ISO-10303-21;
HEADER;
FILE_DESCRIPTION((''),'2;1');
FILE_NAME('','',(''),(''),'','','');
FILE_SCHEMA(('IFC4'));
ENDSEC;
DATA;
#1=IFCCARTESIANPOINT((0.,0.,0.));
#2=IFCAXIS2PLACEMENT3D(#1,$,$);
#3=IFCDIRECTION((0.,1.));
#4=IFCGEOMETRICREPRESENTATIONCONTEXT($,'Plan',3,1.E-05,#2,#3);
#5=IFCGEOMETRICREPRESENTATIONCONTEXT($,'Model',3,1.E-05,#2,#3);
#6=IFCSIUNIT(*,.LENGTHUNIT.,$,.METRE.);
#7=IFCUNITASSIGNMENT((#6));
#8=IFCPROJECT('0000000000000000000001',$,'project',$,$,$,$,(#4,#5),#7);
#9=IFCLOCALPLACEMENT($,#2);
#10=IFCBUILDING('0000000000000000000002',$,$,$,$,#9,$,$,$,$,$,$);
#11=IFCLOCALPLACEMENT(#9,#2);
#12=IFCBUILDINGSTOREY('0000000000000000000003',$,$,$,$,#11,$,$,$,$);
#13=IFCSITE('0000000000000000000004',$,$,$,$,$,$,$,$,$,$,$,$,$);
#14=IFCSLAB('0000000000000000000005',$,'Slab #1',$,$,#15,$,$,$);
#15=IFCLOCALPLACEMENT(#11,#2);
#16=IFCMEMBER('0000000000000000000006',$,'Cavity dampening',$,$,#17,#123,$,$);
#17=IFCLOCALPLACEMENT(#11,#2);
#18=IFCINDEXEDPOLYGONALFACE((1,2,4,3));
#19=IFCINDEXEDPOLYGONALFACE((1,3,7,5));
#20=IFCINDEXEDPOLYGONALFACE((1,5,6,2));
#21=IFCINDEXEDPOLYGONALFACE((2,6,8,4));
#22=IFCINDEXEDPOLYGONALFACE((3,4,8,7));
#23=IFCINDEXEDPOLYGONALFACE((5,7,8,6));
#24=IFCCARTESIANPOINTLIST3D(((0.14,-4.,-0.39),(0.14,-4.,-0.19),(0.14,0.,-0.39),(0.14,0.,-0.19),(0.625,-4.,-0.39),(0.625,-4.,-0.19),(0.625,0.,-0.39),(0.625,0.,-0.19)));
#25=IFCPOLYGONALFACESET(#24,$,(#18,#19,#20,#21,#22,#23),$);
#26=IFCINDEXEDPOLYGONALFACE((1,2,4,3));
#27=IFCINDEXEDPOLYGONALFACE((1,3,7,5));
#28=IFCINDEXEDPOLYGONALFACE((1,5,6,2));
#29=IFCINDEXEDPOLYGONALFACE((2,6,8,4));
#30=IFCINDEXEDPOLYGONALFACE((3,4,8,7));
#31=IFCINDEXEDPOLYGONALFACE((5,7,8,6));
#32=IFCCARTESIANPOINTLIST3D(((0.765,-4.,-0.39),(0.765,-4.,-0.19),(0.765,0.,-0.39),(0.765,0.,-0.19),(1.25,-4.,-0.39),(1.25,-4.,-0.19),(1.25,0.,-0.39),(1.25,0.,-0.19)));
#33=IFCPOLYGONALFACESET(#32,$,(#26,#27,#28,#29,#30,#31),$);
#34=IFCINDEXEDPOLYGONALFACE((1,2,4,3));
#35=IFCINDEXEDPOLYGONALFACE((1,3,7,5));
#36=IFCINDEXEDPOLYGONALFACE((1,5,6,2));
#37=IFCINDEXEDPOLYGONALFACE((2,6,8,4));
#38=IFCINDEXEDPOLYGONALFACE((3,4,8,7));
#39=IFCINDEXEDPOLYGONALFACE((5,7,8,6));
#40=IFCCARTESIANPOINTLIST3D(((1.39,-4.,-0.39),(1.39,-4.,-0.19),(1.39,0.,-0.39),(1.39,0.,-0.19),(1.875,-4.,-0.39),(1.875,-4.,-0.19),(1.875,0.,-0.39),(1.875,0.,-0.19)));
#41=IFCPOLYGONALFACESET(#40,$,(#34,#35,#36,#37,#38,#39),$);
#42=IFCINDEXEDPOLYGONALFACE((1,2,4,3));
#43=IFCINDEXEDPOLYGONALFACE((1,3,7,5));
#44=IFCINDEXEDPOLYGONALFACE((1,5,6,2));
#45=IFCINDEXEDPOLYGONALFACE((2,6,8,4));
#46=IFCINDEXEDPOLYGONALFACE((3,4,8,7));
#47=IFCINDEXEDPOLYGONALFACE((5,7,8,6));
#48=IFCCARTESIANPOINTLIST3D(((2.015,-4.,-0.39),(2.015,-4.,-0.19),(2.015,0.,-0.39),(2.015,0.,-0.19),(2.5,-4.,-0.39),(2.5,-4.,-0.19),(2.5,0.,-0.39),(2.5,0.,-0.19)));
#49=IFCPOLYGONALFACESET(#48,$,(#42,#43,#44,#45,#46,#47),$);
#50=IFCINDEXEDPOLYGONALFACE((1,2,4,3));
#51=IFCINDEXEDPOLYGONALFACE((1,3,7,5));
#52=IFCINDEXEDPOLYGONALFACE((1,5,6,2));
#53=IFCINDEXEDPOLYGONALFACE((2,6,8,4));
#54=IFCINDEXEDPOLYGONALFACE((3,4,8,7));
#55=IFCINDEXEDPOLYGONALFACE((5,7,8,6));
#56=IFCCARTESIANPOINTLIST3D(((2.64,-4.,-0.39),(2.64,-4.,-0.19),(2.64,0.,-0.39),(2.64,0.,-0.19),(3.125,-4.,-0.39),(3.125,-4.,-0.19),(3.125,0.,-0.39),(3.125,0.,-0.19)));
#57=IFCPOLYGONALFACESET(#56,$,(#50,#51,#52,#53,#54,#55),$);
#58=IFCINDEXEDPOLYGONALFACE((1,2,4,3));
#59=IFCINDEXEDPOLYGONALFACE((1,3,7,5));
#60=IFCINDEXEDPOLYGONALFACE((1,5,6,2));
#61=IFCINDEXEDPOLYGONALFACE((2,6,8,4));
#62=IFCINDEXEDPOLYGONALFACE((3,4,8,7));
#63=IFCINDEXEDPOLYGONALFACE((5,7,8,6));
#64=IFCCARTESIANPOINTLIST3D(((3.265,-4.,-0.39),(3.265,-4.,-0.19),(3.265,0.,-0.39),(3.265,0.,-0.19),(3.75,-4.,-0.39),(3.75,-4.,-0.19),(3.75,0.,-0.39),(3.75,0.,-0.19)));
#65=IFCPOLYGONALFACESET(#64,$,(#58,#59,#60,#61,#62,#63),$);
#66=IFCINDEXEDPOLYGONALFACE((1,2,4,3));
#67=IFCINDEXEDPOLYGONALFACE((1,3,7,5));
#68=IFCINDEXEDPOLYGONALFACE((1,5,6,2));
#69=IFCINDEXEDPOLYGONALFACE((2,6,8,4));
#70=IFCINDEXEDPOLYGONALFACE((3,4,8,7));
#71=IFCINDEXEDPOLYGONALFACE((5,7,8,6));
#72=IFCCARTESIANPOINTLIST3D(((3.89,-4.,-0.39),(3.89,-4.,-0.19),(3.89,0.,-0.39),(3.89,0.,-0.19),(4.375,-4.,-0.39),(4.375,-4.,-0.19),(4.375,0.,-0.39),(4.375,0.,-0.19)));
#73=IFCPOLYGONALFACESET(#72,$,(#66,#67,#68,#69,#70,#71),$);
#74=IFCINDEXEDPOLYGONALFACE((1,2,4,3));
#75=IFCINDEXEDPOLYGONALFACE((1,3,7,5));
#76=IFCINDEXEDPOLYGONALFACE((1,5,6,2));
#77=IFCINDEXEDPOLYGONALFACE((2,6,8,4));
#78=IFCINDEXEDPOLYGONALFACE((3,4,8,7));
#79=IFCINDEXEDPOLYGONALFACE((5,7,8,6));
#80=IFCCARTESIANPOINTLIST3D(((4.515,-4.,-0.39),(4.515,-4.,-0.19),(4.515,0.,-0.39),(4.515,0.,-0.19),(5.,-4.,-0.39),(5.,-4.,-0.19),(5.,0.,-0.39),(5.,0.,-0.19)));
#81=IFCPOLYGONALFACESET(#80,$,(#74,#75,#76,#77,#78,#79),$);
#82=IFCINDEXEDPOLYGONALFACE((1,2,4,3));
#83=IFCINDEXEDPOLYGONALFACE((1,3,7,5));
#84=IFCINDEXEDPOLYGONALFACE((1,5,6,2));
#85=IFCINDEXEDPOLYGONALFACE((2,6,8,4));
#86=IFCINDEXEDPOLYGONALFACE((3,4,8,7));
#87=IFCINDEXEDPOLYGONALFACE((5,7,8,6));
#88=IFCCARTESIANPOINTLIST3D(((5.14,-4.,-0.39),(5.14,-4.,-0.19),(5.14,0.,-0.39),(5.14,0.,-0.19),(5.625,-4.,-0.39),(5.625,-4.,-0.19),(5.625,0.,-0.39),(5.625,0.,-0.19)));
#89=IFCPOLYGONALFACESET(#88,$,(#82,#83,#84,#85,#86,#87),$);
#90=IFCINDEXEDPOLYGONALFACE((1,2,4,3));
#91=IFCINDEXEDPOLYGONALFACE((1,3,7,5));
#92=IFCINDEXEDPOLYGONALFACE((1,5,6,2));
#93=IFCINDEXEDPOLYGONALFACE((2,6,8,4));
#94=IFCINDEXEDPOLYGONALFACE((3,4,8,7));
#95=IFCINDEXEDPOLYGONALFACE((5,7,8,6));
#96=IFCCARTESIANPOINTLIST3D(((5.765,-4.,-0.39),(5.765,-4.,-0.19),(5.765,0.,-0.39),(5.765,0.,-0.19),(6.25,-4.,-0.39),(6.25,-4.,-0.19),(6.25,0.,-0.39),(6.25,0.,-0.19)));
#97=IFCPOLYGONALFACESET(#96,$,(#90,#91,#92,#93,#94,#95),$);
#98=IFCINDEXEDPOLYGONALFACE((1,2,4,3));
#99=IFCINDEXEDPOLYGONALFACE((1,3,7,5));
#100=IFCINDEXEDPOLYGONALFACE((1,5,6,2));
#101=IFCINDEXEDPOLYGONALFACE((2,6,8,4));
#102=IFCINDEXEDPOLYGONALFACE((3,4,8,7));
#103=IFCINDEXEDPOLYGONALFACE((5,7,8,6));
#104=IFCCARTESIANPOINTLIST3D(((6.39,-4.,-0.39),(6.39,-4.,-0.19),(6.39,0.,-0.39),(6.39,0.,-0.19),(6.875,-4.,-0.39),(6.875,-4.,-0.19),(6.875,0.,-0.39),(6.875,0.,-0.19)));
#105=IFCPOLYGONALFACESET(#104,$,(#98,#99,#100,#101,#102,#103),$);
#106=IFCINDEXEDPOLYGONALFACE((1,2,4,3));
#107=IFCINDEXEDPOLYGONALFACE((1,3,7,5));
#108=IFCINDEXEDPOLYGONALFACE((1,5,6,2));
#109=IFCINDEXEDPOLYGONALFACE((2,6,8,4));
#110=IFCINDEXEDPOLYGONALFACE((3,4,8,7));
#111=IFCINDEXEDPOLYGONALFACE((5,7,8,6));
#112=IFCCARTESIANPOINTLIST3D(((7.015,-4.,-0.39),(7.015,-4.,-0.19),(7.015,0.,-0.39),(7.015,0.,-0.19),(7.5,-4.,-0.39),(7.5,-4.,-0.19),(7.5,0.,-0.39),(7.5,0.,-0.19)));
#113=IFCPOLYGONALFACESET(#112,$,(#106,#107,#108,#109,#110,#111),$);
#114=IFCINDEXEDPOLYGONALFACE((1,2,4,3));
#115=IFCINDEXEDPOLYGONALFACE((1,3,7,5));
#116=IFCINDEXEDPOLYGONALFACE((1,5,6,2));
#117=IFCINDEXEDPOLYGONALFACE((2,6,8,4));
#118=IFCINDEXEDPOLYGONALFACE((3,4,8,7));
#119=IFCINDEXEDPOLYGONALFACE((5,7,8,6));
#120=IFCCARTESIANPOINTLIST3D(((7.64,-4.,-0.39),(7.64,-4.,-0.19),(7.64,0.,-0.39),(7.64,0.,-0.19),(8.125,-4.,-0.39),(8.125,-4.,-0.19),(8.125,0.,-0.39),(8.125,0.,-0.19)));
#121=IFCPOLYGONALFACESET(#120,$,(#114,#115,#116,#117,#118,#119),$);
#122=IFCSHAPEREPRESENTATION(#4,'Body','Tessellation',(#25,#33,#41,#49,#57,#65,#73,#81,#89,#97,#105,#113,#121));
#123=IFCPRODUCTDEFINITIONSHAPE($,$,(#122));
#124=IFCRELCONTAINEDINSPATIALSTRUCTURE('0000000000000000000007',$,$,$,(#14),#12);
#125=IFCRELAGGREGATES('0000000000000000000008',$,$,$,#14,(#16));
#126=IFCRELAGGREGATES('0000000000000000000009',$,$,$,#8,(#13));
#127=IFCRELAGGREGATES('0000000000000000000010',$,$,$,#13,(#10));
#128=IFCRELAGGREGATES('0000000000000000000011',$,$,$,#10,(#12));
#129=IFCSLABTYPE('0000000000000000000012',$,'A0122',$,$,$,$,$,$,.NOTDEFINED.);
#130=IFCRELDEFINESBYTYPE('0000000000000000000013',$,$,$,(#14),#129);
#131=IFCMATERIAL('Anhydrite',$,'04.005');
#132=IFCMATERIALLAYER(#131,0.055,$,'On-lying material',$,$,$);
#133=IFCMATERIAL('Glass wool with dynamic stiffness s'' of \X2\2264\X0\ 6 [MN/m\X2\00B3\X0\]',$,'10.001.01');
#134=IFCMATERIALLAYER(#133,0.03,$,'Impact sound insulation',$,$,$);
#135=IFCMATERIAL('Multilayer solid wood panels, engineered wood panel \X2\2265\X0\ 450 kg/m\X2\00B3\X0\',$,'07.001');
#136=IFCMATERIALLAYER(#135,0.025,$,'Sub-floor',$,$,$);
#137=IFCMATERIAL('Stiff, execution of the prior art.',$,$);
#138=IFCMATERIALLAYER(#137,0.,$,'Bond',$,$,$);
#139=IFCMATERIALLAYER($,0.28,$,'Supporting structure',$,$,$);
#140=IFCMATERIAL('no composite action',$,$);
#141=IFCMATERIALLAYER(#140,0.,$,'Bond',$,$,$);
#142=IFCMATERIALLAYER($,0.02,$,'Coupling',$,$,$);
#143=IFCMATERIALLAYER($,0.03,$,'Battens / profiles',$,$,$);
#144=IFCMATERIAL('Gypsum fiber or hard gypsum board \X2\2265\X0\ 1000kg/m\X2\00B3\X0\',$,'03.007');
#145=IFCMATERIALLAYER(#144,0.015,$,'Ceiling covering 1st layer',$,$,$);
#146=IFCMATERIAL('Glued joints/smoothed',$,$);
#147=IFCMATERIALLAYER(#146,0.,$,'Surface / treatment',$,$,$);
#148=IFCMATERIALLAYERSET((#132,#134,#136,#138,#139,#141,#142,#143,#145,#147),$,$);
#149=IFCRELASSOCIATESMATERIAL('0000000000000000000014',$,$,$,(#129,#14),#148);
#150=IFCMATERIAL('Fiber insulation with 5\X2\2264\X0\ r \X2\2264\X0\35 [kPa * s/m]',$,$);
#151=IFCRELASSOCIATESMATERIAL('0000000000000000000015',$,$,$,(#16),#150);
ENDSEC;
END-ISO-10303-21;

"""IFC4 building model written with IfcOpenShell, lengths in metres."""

from ifc_helpers import new_model, si_unit, direction, frame, frame_2d, origin, place, context, project, spatial, rectangle, extrude, material, layer, layer_set, type_object, element, aggregate, save


model = new_model("IFC4")

# Units and contexts
plan_context = context("Plan", 3, precision=1e-05, world=origin(), true_north=direction((0.0, 1.0)))
model_context = context("Model", 3, precision=1e-05, world=origin(), true_north=direction((0.0, 1.0)))
ifc_project = project(units=[si_unit("LENGTHUNIT", "METRE")], contexts=[plan_context, model_context])

# Site, building, storey
site = spatial("IfcSite", under=ifc_project)
building_placement = place(None, origin())
building = spatial("IfcBuilding", under=site, at=building_placement)
storey_placement = place(building_placement, origin())
storey = spatial("IfcBuildingStorey", under=building, at=storey_placement)

# Slab, member
ifc_material_1 = material(Name="Anhydrite", Category="04.005")
ifc_layer_1 = layer(ifc_material_1, 0.055, Name="On-lying material")
ifc_material_2 = material(Name="Glass wool with dynamic stiffness s' of ≤ 6 [MN/m³]", Category="10.001.01")
ifc_layer_2 = layer(ifc_material_2, 0.03, Name="Impact sound insulation")
ifc_material_3 = material(Name="Multilayer solid wood panels, engineered wood panel ≥ 450 kg/m³", Category="07.001")
ifc_layer_3 = layer(ifc_material_3, 0.025, Name="Sub-floor")
ifc_material_4 = material(Name="Stiff, execution of the prior art.")
ifc_layer_4 = layer(ifc_material_4, 0.0, Name="Bond")
ifc_layer_5 = layer(None, 0.28, Name="Supporting structure")
ifc_material_5 = material(Name="no composite action")
ifc_layer_6 = layer(ifc_material_5, 0.0, Name="Bond")
ifc_layer_7 = layer(None, 0.02, Name="Coupling")
ifc_layer_8 = layer(None, 0.03, Name="Battens / profiles")
ifc_material_6 = material(Name="Gypsum fiber or hard gypsum board ≥ 1000kg/m³", Category="03.007")
ifc_layer_9 = layer(ifc_material_6, 0.015, Name="Ceiling covering 1st layer")
ifc_material_7 = material(Name="Glued joints/smoothed")
ifc_layer_10 = layer(ifc_material_7, 0.0, Name="Surface / treatment")
ifc_layer_set = layer_set([ifc_layer_1, ifc_layer_2, ifc_layer_3, ifc_layer_4, ifc_layer_5, ifc_layer_6, ifc_layer_7, ifc_layer_8, ifc_layer_9, ifc_layer_10])
slab_type = type_object("IfcSlabType", Name="A0122", PredefinedType="NOTDEFINED", material=ifc_layer_set)
slab_placement = place(None, frame((0.0, 0.0, 0.0), z_axis=(0.0, 0.0, -1.0), x_axis=(1.0, 0.0, 0.0)))
slab = element("IfcSlab", 1, at=slab_placement, inside=storey, type_object=slab_type, material=ifc_layer_set, Name="Slab #1")
ifc_material_8 = material(Name="Fiber insulation with 5≤ r ≤35 [kPa * s/m]")
member_1_placement = place(slab_placement, origin())
member_1 = element("IfcMember", 2, at=member_1_placement, material=ifc_material_8, Name="Cavity dampening", context=plan_context, shape_type="SweptSolid", body=[
    extrude(rectangle(XDim=0.485, YDim=0.2, at=frame_2d((0.2425, 0.1), x_axis=(1.0, 0.0))), frame((0.14, 4.0, 0.19), z_axis=(0.0, -1.0, 0.0), x_axis=(1.0, 0.0, 0.0)), (0.0, 0.0, 1.0), 4.0),
    extrude(rectangle(XDim=0.485, YDim=0.2, at=frame_2d((0.2425, 0.1), x_axis=(1.0, 0.0))), frame((0.765, 4.0, 0.19), z_axis=(0.0, -1.0, 0.0), x_axis=(1.0, 0.0, 0.0)), (0.0, 0.0, 1.0), 4.0),
    extrude(rectangle(XDim=0.485, YDim=0.2, at=frame_2d((0.2425, 0.1), x_axis=(1.0, 0.0))), frame((1.39, 4.0, 0.19), z_axis=(0.0, -1.0, 0.0), x_axis=(1.0, 0.0, 0.0)), (0.0, 0.0, 1.0), 4.0),
    extrude(rectangle(XDim=0.485, YDim=0.2, at=frame_2d((0.2425, 0.1), x_axis=(1.0, 0.0))), frame((2.015, 4.0, 0.19), z_axis=(0.0, -1.0, 0.0), x_axis=(1.0, 0.0, 0.0)), (0.0, 0.0, 1.0), 4.0),
    extrude(rectangle(XDim=0.485, YDim=0.2, at=frame_2d((0.2425, 0.1), x_axis=(1.0, 0.0))), frame((2.64, 4.0, 0.19), z_axis=(0.0, -1.0, 0.0), x_axis=(1.0, 0.0, 0.0)), (0.0, 0.0, 1.0), 4.0),
    extrude(rectangle(XDim=0.485, YDim=0.2, at=frame_2d((0.2425, 0.1), x_axis=(1.0, 0.0))), frame((3.265, 4.0, 0.19), z_axis=(0.0, -1.0, 0.0), x_axis=(1.0, 0.0, 0.0)), (0.0, 0.0, 1.0), 4.0),
    extrude(rectangle(XDim=0.485, YDim=0.2, at=frame_2d((0.2425, 0.1), x_axis=(1.0, 0.0))), frame((3.89, 4.0, 0.19), z_axis=(0.0, -1.0, 0.0), x_axis=(1.0, 0.0, 0.0)), (0.0, 0.0, 1.0), 4.0),
    extrude(rectangle(XDim=0.485, YDim=0.2, at=frame_2d((0.2425, 0.1), x_axis=(1.0, 0.0))), frame((4.515, 4.0, 0.19), z_axis=(0.0, -1.0, 0.0), x_axis=(1.0, 0.0, 0.0)), (0.0, 0.0, 1.0), 4.0),
    extrude(rectangle(XDim=0.485, YDim=0.2, at=frame_2d((0.2425, 0.1), x_axis=(1.0, 0.0))), frame((5.14, 4.0, 0.19), z_axis=(0.0, -1.0, 0.0), x_axis=(1.0, 0.0, 0.0)), (0.0, 0.0, 1.0), 4.0),
    extrude(rectangle(XDim=0.485, YDim=0.2, at=frame_2d((0.2425, 0.1), x_axis=(1.0, 0.0))), frame((5.765, 4.0, 0.19), z_axis=(0.0, -1.0, 0.0), x_axis=(1.0, 0.0, 0.0)), (0.0, 0.0, 1.0), 4.0),
    extrude(rectangle(XDim=0.485, YDim=0.2, at=frame_2d((0.2425, 0.1), x_axis=(1.0, 0.0))), frame((6.39, 4.0, 0.19), z_axis=(0.0, -1.0, 0.0), x_axis=(1.0, 0.0, 0.0)), (0.0, 0.0, 1.0), 4.0),
    extrude(rectangle(XDim=0.485, YDim=0.2, at=frame_2d((0.2425, 0.1), x_axis=(1.0, 0.0))), frame((7.015, 4.0, 0.19), z_axis=(0.0, -1.0, 0.0), x_axis=(1.0, 0.0, 0.0)), (0.0, 0.0, 1.0), 4.0),
    extrude(rectangle(XDim=0.485, YDim=0.2, at=frame_2d((0.2425, 0.1), x_axis=(1.0, 0.0))), frame((7.64, 4.0, 0.19), z_axis=(0.0, -1.0, 0.0), x_axis=(1.0, 0.0, 0.0)), (0.0, 0.0, 1.0), 4.0),
])
aggregate(slab, [member_1])

save(model, "model.ifc")
